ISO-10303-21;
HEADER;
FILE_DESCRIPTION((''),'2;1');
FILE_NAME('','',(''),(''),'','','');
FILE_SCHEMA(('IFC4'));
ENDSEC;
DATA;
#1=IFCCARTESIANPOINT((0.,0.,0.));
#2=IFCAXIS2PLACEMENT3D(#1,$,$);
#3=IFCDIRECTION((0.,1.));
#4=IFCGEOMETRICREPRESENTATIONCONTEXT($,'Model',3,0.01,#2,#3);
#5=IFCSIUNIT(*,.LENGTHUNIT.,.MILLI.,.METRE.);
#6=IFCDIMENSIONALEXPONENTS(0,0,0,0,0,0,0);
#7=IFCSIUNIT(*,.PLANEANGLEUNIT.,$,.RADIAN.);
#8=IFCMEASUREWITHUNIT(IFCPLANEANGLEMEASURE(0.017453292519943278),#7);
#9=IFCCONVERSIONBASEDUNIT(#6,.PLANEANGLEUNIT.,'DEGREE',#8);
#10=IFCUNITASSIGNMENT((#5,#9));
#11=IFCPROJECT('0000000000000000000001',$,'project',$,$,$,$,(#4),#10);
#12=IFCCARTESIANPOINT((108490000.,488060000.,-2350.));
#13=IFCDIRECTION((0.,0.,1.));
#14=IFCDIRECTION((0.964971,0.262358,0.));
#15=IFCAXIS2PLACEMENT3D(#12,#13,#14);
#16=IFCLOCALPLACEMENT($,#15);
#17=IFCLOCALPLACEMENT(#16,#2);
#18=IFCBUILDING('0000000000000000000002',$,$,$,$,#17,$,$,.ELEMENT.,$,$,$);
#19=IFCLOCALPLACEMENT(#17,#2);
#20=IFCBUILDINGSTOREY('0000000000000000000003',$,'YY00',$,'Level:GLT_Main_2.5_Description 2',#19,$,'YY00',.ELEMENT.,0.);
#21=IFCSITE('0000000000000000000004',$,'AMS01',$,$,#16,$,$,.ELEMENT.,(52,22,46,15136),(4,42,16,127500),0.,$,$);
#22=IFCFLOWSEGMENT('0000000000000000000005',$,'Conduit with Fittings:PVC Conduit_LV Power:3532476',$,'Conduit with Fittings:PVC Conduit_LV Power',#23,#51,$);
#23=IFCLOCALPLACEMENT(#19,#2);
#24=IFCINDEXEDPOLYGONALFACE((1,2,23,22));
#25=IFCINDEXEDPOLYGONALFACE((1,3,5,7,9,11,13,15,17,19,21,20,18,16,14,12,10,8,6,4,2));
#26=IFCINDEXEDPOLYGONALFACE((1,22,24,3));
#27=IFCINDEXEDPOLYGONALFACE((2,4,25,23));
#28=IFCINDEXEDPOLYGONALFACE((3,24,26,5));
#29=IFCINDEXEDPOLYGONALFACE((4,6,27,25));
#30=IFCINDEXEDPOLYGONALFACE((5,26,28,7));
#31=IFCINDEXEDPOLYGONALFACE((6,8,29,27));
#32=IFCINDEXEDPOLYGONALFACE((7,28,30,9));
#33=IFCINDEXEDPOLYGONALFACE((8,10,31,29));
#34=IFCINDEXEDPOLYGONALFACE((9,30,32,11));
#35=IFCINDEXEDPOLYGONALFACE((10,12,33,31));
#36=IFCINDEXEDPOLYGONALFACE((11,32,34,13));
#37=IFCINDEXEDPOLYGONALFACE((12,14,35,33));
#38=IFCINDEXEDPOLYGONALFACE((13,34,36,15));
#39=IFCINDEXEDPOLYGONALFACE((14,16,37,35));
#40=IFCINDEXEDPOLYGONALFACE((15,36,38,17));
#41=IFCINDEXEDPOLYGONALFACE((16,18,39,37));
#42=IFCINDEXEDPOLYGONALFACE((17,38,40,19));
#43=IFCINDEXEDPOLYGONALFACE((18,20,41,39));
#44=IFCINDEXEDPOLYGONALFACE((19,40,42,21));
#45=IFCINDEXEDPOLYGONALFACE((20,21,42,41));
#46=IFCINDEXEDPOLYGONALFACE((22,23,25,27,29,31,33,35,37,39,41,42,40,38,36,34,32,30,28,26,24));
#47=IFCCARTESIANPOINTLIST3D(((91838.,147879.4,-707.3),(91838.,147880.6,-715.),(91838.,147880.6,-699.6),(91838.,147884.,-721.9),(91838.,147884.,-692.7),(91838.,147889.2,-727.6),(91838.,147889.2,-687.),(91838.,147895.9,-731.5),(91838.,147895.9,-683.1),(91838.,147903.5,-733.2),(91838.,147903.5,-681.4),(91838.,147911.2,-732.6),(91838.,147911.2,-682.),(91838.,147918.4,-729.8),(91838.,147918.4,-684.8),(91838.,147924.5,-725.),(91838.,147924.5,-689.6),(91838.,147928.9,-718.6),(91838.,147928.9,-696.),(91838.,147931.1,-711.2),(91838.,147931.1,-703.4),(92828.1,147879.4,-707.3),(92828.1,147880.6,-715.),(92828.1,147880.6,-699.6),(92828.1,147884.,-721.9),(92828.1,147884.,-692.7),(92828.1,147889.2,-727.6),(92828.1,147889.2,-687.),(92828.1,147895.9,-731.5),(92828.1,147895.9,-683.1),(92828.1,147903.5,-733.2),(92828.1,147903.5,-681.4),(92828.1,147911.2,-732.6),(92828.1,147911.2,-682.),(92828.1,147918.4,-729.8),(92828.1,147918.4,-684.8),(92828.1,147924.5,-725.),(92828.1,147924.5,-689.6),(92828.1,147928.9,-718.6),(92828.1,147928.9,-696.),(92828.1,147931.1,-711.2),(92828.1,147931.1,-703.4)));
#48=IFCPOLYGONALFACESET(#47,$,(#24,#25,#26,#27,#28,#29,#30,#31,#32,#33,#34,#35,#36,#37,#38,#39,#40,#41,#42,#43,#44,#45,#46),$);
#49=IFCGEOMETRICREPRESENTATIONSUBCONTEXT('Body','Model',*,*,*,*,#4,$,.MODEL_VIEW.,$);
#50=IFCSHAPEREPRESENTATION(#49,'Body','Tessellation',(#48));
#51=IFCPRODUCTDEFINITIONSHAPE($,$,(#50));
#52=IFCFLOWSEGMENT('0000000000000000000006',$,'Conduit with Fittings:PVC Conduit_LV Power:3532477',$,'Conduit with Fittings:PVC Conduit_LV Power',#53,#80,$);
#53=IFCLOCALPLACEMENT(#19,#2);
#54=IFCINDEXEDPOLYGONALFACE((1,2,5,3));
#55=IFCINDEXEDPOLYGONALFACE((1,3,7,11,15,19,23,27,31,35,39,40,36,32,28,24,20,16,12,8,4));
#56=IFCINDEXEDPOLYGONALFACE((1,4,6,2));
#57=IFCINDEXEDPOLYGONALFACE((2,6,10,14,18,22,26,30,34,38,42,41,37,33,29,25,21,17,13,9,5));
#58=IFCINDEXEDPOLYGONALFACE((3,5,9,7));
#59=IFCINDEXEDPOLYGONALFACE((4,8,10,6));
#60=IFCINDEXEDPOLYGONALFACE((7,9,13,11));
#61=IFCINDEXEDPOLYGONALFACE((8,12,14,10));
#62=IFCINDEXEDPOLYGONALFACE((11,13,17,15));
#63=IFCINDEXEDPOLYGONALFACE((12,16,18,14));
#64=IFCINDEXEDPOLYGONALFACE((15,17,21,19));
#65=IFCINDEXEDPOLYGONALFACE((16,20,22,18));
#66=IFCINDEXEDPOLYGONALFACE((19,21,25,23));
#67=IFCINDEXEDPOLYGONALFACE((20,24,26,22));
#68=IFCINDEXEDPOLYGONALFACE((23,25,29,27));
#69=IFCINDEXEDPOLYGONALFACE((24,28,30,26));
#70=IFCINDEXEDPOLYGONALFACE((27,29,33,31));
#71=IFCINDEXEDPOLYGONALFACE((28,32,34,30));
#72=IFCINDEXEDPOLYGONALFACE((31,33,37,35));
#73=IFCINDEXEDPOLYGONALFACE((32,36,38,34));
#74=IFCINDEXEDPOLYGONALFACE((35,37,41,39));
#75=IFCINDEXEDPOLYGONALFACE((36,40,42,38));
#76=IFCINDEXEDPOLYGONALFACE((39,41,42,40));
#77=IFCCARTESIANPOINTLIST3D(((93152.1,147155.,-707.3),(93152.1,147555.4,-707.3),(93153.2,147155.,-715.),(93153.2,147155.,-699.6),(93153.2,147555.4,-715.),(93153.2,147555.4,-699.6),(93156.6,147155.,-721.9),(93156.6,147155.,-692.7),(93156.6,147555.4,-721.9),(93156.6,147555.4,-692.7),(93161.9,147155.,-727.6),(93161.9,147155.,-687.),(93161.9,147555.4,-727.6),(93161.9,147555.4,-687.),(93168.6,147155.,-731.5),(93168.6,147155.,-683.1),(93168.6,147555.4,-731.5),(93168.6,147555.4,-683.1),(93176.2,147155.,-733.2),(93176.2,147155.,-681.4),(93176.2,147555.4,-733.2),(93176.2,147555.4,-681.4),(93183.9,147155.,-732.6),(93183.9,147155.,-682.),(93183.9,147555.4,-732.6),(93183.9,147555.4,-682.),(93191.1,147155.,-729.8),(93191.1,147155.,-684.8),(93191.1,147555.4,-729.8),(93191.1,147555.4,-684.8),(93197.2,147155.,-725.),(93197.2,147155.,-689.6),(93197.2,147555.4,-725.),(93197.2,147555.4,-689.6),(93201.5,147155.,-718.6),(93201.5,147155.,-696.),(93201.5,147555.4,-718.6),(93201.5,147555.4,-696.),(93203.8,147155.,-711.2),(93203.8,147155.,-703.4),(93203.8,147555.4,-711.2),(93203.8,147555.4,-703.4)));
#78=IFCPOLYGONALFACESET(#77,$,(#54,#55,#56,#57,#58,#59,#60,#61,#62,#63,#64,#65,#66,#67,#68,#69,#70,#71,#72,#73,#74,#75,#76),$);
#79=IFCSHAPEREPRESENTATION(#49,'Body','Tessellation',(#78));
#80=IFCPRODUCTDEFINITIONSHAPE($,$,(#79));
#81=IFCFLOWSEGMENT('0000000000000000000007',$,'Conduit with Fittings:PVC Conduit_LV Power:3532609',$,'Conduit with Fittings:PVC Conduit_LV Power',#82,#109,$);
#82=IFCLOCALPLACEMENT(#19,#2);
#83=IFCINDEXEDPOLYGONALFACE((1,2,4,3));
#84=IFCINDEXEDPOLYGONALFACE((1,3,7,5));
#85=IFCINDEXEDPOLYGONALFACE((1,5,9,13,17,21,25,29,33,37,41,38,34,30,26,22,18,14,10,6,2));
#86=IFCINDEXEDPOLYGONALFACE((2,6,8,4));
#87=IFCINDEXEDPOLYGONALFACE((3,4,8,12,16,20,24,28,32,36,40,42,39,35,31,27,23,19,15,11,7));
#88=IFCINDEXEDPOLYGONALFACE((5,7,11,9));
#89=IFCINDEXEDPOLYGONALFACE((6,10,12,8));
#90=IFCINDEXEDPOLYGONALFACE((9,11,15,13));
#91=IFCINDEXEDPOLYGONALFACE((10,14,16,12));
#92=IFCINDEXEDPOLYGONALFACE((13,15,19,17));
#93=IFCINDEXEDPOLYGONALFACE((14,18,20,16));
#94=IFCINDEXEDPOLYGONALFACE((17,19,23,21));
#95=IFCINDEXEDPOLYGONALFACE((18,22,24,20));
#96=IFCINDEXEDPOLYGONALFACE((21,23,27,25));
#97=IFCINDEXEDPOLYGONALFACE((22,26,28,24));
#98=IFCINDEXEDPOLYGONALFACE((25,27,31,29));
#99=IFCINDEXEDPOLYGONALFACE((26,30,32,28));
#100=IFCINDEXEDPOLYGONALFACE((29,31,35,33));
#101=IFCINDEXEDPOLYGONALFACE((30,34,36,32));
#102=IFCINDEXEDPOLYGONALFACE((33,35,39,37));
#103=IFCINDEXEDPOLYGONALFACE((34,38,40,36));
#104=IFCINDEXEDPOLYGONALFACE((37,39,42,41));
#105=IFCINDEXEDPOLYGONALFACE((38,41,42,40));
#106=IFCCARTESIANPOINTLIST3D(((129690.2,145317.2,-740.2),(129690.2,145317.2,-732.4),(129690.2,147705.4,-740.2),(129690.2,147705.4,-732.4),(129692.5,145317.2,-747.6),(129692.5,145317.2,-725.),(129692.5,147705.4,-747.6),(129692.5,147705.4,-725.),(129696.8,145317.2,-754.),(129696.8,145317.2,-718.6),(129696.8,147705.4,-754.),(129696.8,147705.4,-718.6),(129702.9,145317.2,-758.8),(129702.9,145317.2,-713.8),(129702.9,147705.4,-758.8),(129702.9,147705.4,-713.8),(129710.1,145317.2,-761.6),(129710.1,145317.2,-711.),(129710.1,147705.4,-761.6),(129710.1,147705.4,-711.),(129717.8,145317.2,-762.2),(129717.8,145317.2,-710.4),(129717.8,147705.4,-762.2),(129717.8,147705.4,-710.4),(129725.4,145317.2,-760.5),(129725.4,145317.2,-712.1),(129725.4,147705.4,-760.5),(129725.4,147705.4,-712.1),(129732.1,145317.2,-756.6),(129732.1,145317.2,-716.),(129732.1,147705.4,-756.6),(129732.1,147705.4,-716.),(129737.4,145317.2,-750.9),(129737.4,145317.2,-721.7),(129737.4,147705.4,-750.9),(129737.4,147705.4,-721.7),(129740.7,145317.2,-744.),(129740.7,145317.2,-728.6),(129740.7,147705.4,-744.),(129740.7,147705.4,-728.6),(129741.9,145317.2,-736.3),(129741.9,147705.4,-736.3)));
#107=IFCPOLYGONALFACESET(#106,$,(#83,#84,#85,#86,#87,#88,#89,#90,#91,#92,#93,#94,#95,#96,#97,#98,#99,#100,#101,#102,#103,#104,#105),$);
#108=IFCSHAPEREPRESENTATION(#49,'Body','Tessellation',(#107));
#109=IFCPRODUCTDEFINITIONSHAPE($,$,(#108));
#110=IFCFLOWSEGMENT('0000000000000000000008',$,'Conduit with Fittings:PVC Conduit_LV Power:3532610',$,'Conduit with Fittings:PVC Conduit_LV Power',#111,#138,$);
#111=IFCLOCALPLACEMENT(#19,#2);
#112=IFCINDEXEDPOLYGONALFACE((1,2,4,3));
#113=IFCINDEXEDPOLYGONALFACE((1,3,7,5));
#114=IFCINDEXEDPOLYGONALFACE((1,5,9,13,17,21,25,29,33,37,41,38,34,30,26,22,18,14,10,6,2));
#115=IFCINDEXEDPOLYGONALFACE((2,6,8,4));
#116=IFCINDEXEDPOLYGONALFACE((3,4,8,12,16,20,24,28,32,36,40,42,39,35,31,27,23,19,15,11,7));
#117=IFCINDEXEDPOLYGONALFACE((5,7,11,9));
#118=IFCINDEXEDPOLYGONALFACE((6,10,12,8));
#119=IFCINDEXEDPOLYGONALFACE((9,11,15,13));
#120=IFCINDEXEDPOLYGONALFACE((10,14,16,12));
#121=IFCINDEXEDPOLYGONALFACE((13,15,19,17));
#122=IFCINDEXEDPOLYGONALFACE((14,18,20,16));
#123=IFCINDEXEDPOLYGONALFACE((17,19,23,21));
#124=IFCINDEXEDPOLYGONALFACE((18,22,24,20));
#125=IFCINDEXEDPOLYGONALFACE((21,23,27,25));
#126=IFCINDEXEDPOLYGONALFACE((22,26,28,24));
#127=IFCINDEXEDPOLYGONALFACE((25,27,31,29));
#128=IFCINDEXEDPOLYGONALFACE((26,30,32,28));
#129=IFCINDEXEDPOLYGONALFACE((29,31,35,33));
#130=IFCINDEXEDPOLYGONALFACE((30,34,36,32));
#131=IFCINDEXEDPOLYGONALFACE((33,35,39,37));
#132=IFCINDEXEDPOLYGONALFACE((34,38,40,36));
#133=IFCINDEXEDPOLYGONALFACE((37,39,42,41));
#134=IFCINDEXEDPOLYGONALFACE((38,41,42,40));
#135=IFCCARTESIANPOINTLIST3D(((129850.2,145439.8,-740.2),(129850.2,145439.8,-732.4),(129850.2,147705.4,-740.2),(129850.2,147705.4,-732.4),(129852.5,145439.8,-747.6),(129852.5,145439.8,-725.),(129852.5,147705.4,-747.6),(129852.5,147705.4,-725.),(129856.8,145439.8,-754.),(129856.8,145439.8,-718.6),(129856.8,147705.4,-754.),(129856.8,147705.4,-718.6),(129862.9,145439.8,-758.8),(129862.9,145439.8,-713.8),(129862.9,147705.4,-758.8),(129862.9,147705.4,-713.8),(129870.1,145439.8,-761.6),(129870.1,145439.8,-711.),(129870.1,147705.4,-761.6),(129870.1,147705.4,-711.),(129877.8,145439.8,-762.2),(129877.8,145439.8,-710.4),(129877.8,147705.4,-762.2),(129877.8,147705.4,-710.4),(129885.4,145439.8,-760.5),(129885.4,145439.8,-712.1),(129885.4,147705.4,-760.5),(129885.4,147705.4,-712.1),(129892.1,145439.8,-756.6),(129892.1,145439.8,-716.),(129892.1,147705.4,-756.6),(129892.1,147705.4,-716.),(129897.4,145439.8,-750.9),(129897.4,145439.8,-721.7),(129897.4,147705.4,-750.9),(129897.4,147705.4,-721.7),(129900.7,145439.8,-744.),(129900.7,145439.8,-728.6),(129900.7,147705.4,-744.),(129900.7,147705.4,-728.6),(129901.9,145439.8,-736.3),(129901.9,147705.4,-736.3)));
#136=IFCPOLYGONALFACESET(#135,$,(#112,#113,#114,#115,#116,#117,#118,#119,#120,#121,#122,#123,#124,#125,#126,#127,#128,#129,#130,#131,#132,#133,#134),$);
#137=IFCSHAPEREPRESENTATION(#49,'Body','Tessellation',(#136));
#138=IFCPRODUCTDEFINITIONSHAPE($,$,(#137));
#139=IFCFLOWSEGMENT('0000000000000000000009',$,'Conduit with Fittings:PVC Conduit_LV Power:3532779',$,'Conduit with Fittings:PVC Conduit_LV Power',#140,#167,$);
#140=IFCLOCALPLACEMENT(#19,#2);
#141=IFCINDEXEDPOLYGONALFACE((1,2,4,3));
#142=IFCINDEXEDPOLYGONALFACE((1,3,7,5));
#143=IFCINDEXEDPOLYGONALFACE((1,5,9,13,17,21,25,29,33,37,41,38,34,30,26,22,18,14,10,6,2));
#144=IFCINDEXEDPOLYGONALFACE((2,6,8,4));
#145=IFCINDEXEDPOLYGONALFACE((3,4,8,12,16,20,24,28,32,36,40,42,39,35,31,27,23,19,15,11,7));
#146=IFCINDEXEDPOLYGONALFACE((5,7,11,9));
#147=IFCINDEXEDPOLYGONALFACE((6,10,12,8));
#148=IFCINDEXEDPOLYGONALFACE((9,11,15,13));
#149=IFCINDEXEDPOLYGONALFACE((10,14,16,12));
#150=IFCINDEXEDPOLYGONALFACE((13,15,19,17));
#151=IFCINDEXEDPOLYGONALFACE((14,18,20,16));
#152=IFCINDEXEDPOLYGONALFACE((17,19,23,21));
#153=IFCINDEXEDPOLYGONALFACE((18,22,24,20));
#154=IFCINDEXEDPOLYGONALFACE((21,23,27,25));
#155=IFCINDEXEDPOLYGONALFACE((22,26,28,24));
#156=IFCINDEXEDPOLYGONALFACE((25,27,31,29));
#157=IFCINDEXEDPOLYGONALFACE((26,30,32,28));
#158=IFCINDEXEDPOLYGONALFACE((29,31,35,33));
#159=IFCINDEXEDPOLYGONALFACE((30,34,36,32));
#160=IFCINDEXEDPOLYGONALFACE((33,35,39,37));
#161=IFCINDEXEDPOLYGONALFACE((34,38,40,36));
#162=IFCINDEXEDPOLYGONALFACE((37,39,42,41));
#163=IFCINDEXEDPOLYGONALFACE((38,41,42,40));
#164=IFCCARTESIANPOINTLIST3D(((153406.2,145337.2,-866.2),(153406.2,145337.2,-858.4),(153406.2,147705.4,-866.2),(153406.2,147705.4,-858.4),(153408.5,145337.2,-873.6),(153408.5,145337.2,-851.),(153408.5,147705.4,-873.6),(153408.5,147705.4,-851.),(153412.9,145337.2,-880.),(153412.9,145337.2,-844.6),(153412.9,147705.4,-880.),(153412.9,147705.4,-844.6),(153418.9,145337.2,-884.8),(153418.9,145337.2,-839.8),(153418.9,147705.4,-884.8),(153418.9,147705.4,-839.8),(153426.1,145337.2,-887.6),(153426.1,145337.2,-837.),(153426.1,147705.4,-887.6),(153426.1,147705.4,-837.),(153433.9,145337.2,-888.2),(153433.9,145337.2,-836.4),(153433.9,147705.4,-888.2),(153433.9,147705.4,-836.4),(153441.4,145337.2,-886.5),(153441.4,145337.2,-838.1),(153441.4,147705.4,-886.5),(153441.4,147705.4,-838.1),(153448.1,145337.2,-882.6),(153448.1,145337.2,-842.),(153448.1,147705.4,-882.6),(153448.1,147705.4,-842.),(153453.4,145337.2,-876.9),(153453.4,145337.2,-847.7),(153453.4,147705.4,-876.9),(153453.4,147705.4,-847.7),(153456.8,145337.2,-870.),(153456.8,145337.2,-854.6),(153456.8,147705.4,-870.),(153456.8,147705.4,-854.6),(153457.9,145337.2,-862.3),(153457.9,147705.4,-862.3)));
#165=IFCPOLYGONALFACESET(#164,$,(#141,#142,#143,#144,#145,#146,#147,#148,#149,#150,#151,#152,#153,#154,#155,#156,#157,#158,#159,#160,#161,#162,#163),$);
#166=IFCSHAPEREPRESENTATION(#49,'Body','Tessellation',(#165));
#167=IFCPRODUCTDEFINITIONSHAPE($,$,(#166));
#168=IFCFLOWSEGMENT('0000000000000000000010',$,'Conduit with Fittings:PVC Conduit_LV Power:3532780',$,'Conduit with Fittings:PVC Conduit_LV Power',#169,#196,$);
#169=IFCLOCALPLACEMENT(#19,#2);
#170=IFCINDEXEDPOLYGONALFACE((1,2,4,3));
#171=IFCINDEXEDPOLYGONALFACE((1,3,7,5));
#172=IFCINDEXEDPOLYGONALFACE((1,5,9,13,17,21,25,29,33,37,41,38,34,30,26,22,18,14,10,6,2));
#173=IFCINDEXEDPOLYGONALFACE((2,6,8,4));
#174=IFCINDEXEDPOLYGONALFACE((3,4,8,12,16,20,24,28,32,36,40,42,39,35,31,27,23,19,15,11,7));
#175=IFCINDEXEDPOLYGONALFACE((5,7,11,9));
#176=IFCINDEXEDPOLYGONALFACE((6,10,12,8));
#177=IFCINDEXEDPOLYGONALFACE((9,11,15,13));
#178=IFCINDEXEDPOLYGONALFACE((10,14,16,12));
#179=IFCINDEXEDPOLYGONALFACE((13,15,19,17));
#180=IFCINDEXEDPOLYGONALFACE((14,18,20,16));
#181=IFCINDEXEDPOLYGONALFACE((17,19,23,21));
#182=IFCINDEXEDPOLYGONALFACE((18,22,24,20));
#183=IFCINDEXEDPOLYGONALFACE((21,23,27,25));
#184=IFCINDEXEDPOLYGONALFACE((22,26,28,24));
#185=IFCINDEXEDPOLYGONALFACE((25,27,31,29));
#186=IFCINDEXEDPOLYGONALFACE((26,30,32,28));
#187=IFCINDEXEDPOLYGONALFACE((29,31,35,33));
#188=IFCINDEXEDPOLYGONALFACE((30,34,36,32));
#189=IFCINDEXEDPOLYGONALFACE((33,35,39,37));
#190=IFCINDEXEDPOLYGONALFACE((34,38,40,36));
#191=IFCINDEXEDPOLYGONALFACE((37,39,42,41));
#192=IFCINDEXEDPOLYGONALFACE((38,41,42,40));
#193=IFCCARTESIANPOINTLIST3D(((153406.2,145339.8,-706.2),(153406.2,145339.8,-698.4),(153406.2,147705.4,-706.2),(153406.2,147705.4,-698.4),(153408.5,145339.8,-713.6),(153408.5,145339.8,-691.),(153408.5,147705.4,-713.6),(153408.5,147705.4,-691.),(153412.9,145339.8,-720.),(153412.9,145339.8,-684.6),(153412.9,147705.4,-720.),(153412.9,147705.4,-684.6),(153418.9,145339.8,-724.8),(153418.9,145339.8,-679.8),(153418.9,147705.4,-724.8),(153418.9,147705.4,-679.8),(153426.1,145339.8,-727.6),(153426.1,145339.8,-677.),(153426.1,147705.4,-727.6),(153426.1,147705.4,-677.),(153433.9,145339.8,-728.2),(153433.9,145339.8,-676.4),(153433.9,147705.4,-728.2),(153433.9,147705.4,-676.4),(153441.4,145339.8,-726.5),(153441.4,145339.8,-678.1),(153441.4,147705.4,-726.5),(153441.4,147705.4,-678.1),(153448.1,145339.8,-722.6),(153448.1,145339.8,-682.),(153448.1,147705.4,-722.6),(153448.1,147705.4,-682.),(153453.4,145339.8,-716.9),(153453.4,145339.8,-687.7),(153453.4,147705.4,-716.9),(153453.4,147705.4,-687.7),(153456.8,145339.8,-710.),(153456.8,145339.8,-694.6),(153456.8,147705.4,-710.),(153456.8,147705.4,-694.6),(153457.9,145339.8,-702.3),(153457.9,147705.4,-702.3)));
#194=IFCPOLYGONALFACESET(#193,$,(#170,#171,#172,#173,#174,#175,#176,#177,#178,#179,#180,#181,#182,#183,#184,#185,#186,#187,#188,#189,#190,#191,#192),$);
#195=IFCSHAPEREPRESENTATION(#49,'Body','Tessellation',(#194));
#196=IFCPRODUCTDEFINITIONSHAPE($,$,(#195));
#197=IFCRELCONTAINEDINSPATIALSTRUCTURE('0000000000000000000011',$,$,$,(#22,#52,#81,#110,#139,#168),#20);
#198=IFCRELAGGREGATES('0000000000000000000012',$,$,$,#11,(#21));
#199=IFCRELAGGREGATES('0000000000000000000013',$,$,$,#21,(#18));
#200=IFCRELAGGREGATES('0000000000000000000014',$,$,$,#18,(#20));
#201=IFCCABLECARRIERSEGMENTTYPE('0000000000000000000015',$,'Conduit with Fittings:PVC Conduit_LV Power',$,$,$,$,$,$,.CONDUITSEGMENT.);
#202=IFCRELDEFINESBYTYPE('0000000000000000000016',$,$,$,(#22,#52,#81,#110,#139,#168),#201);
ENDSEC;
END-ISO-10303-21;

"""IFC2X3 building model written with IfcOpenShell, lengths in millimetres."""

from ifc_helpers import new_model, entity, si_unit, converted_unit, direction, frame, frame_2d, origin, origin_2d_with_axis, place, context, subcontext, project, spatial, circle, extrude, type_object, element, save


model = new_model("IFC2X3")

# Units and contexts
model_context = context("Model", 3, precision=0.01, world=origin(), true_north=direction((0.0, 1.0)))
body_context = subcontext(model_context, "Body", "Model", "MODEL_VIEW")
ifc_project = project(units=[si_unit("LENGTHUNIT", "METRE", prefix="MILLI"), converted_unit("PLANEANGLEUNIT", "DEGREE", entity("IfcPlaneAngleMeasure", 0.017453292519943278), si_unit("PLANEANGLEUNIT", "RADIAN"), dimensions=[0, 0, 0, 0, 0, 0, 0])], contexts=[model_context])

# Site, building, storey
site_placement = place(None, frame((108490000.0, 488060000.0, -2350.0), z_axis=(0.0, 0.0, 1.0), x_axis=(0.964971, 0.262358, 0.0)))
site = spatial("IfcSite", under=ifc_project, at=site_placement, Name="AMS01", CompositionType="ELEMENT", RefLatitude=(52, 22, 46, 15136), RefLongitude=(4, 42, 16, 127500), RefElevation=0.0)
building_placement = place(site_placement, origin())
building = spatial("IfcBuilding", under=site, at=building_placement, CompositionType="ELEMENT")
storey_placement = place(building_placement, origin())
storey = spatial("IfcBuildingStorey", under=building, at=storey_placement, Name="YY00", ObjectType="Level:GLT_Main_2.5_Description 2", LongName="YY00", CompositionType="ELEMENT", Elevation=0.0)

# Flow segments
cable_carrier_segment_type = type_object("IfcCableCarrierSegmentType", Name="Conduit with Fittings:PVC Conduit_LV Power", PredefinedType="CONDUITSEGMENT")
flow_segment_1_placement = place(storey_placement, origin())
element("IfcFlowSegment", 1, at=flow_segment_1_placement, inside=storey, type_object=cable_carrier_segment_type, Name="Conduit with Fittings:PVC Conduit_LV Power:3532476", ObjectType="Conduit with Fittings:PVC Conduit_LV Power", context=body_context, shape_type="SweptSolid", body=[
    extrude(circle(Radius=26.0, at=origin_2d_with_axis()), frame((91838.0, 147905.4, -707.3), z_axis=(1.0, 0.0, 0.0), x_axis=(0.0, -1.0, 0.0)), (0.0, 0.0, 1.0), 990.1),
])
flow_segment_2_placement = place(storey_placement, origin())
element("IfcFlowSegment", 2, at=flow_segment_2_placement, inside=storey, type_object=cable_carrier_segment_type, Name="Conduit with Fittings:PVC Conduit_LV Power:3532477", ObjectType="Conduit with Fittings:PVC Conduit_LV Power", context=body_context, shape_type="SweptSolid", body=[
    extrude(circle(Radius=26.0, at=frame_2d((0.0, 0.0), x_axis=(1.0, 0.0))), frame((93178.1, 147155.0, -707.3), z_axis=(0.0, 1.0, 0.0), x_axis=(-1.0, 0.0, 0.0)), (0.0, 0.0, 1.0), 400.4),
])
flow_segment_3_placement = place(storey_placement, origin())
element("IfcFlowSegment", 3, at=flow_segment_3_placement, inside=storey, type_object=cable_carrier_segment_type, Name="Conduit with Fittings:PVC Conduit_LV Power:3532609", ObjectType="Conduit with Fittings:PVC Conduit_LV Power", context=body_context, shape_type="SweptSolid", body=[
    extrude(circle(Radius=26.0, at=origin_2d_with_axis()), frame((129715.9, 145317.2, -736.3), z_axis=(0.0, 1.0, 0.0), x_axis=(1.0, 0.0, 0.0)), (0.0, 0.0, 1.0), 2388.2),
])
flow_segment_4_placement = place(storey_placement, origin())
element("IfcFlowSegment", 4, at=flow_segment_4_placement, inside=storey, type_object=cable_carrier_segment_type, Name="Conduit with Fittings:PVC Conduit_LV Power:3532610", ObjectType="Conduit with Fittings:PVC Conduit_LV Power", context=body_context, shape_type="SweptSolid", body=[
    extrude(circle(Radius=26.0, at=origin_2d_with_axis()), frame((129875.9, 145439.8, -736.3), z_axis=(0.0, 1.0, 0.0), x_axis=(1.0, 0.0, 0.0)), (0.0, 0.0, 1.0), 2265.7),
])
flow_segment_5_placement = place(storey_placement, origin())
element("IfcFlowSegment", 5, at=flow_segment_5_placement, inside=storey, type_object=cable_carrier_segment_type, Name="Conduit with Fittings:PVC Conduit_LV Power:3532779", ObjectType="Conduit with Fittings:PVC Conduit_LV Power", context=body_context, shape_type="SweptSolid", body=[
    extrude(circle(Radius=26.0, at=origin_2d_with_axis()), frame((153431.9, 145337.2, -862.3), z_axis=(0.0, 1.0, 0.0), x_axis=(1.0, 0.0, 0.0)), (0.0, 0.0, 1.0), 2368.2),
])
flow_segment_6_placement = place(storey_placement, origin())
element("IfcFlowSegment", 6, at=flow_segment_6_placement, inside=storey, type_object=cable_carrier_segment_type, Name="Conduit with Fittings:PVC Conduit_LV Power:3532780", ObjectType="Conduit with Fittings:PVC Conduit_LV Power", context=body_context, shape_type="SweptSolid", body=[
    extrude(circle(Radius=26.0, at=origin_2d_with_axis()), frame((153431.9, 145339.8, -702.3), z_axis=(0.0, 1.0, 0.0), x_axis=(1.0, 0.0, 0.0)), (0.0, 0.0, 1.0), 2365.7),
])

save(model, "model.ifc")
